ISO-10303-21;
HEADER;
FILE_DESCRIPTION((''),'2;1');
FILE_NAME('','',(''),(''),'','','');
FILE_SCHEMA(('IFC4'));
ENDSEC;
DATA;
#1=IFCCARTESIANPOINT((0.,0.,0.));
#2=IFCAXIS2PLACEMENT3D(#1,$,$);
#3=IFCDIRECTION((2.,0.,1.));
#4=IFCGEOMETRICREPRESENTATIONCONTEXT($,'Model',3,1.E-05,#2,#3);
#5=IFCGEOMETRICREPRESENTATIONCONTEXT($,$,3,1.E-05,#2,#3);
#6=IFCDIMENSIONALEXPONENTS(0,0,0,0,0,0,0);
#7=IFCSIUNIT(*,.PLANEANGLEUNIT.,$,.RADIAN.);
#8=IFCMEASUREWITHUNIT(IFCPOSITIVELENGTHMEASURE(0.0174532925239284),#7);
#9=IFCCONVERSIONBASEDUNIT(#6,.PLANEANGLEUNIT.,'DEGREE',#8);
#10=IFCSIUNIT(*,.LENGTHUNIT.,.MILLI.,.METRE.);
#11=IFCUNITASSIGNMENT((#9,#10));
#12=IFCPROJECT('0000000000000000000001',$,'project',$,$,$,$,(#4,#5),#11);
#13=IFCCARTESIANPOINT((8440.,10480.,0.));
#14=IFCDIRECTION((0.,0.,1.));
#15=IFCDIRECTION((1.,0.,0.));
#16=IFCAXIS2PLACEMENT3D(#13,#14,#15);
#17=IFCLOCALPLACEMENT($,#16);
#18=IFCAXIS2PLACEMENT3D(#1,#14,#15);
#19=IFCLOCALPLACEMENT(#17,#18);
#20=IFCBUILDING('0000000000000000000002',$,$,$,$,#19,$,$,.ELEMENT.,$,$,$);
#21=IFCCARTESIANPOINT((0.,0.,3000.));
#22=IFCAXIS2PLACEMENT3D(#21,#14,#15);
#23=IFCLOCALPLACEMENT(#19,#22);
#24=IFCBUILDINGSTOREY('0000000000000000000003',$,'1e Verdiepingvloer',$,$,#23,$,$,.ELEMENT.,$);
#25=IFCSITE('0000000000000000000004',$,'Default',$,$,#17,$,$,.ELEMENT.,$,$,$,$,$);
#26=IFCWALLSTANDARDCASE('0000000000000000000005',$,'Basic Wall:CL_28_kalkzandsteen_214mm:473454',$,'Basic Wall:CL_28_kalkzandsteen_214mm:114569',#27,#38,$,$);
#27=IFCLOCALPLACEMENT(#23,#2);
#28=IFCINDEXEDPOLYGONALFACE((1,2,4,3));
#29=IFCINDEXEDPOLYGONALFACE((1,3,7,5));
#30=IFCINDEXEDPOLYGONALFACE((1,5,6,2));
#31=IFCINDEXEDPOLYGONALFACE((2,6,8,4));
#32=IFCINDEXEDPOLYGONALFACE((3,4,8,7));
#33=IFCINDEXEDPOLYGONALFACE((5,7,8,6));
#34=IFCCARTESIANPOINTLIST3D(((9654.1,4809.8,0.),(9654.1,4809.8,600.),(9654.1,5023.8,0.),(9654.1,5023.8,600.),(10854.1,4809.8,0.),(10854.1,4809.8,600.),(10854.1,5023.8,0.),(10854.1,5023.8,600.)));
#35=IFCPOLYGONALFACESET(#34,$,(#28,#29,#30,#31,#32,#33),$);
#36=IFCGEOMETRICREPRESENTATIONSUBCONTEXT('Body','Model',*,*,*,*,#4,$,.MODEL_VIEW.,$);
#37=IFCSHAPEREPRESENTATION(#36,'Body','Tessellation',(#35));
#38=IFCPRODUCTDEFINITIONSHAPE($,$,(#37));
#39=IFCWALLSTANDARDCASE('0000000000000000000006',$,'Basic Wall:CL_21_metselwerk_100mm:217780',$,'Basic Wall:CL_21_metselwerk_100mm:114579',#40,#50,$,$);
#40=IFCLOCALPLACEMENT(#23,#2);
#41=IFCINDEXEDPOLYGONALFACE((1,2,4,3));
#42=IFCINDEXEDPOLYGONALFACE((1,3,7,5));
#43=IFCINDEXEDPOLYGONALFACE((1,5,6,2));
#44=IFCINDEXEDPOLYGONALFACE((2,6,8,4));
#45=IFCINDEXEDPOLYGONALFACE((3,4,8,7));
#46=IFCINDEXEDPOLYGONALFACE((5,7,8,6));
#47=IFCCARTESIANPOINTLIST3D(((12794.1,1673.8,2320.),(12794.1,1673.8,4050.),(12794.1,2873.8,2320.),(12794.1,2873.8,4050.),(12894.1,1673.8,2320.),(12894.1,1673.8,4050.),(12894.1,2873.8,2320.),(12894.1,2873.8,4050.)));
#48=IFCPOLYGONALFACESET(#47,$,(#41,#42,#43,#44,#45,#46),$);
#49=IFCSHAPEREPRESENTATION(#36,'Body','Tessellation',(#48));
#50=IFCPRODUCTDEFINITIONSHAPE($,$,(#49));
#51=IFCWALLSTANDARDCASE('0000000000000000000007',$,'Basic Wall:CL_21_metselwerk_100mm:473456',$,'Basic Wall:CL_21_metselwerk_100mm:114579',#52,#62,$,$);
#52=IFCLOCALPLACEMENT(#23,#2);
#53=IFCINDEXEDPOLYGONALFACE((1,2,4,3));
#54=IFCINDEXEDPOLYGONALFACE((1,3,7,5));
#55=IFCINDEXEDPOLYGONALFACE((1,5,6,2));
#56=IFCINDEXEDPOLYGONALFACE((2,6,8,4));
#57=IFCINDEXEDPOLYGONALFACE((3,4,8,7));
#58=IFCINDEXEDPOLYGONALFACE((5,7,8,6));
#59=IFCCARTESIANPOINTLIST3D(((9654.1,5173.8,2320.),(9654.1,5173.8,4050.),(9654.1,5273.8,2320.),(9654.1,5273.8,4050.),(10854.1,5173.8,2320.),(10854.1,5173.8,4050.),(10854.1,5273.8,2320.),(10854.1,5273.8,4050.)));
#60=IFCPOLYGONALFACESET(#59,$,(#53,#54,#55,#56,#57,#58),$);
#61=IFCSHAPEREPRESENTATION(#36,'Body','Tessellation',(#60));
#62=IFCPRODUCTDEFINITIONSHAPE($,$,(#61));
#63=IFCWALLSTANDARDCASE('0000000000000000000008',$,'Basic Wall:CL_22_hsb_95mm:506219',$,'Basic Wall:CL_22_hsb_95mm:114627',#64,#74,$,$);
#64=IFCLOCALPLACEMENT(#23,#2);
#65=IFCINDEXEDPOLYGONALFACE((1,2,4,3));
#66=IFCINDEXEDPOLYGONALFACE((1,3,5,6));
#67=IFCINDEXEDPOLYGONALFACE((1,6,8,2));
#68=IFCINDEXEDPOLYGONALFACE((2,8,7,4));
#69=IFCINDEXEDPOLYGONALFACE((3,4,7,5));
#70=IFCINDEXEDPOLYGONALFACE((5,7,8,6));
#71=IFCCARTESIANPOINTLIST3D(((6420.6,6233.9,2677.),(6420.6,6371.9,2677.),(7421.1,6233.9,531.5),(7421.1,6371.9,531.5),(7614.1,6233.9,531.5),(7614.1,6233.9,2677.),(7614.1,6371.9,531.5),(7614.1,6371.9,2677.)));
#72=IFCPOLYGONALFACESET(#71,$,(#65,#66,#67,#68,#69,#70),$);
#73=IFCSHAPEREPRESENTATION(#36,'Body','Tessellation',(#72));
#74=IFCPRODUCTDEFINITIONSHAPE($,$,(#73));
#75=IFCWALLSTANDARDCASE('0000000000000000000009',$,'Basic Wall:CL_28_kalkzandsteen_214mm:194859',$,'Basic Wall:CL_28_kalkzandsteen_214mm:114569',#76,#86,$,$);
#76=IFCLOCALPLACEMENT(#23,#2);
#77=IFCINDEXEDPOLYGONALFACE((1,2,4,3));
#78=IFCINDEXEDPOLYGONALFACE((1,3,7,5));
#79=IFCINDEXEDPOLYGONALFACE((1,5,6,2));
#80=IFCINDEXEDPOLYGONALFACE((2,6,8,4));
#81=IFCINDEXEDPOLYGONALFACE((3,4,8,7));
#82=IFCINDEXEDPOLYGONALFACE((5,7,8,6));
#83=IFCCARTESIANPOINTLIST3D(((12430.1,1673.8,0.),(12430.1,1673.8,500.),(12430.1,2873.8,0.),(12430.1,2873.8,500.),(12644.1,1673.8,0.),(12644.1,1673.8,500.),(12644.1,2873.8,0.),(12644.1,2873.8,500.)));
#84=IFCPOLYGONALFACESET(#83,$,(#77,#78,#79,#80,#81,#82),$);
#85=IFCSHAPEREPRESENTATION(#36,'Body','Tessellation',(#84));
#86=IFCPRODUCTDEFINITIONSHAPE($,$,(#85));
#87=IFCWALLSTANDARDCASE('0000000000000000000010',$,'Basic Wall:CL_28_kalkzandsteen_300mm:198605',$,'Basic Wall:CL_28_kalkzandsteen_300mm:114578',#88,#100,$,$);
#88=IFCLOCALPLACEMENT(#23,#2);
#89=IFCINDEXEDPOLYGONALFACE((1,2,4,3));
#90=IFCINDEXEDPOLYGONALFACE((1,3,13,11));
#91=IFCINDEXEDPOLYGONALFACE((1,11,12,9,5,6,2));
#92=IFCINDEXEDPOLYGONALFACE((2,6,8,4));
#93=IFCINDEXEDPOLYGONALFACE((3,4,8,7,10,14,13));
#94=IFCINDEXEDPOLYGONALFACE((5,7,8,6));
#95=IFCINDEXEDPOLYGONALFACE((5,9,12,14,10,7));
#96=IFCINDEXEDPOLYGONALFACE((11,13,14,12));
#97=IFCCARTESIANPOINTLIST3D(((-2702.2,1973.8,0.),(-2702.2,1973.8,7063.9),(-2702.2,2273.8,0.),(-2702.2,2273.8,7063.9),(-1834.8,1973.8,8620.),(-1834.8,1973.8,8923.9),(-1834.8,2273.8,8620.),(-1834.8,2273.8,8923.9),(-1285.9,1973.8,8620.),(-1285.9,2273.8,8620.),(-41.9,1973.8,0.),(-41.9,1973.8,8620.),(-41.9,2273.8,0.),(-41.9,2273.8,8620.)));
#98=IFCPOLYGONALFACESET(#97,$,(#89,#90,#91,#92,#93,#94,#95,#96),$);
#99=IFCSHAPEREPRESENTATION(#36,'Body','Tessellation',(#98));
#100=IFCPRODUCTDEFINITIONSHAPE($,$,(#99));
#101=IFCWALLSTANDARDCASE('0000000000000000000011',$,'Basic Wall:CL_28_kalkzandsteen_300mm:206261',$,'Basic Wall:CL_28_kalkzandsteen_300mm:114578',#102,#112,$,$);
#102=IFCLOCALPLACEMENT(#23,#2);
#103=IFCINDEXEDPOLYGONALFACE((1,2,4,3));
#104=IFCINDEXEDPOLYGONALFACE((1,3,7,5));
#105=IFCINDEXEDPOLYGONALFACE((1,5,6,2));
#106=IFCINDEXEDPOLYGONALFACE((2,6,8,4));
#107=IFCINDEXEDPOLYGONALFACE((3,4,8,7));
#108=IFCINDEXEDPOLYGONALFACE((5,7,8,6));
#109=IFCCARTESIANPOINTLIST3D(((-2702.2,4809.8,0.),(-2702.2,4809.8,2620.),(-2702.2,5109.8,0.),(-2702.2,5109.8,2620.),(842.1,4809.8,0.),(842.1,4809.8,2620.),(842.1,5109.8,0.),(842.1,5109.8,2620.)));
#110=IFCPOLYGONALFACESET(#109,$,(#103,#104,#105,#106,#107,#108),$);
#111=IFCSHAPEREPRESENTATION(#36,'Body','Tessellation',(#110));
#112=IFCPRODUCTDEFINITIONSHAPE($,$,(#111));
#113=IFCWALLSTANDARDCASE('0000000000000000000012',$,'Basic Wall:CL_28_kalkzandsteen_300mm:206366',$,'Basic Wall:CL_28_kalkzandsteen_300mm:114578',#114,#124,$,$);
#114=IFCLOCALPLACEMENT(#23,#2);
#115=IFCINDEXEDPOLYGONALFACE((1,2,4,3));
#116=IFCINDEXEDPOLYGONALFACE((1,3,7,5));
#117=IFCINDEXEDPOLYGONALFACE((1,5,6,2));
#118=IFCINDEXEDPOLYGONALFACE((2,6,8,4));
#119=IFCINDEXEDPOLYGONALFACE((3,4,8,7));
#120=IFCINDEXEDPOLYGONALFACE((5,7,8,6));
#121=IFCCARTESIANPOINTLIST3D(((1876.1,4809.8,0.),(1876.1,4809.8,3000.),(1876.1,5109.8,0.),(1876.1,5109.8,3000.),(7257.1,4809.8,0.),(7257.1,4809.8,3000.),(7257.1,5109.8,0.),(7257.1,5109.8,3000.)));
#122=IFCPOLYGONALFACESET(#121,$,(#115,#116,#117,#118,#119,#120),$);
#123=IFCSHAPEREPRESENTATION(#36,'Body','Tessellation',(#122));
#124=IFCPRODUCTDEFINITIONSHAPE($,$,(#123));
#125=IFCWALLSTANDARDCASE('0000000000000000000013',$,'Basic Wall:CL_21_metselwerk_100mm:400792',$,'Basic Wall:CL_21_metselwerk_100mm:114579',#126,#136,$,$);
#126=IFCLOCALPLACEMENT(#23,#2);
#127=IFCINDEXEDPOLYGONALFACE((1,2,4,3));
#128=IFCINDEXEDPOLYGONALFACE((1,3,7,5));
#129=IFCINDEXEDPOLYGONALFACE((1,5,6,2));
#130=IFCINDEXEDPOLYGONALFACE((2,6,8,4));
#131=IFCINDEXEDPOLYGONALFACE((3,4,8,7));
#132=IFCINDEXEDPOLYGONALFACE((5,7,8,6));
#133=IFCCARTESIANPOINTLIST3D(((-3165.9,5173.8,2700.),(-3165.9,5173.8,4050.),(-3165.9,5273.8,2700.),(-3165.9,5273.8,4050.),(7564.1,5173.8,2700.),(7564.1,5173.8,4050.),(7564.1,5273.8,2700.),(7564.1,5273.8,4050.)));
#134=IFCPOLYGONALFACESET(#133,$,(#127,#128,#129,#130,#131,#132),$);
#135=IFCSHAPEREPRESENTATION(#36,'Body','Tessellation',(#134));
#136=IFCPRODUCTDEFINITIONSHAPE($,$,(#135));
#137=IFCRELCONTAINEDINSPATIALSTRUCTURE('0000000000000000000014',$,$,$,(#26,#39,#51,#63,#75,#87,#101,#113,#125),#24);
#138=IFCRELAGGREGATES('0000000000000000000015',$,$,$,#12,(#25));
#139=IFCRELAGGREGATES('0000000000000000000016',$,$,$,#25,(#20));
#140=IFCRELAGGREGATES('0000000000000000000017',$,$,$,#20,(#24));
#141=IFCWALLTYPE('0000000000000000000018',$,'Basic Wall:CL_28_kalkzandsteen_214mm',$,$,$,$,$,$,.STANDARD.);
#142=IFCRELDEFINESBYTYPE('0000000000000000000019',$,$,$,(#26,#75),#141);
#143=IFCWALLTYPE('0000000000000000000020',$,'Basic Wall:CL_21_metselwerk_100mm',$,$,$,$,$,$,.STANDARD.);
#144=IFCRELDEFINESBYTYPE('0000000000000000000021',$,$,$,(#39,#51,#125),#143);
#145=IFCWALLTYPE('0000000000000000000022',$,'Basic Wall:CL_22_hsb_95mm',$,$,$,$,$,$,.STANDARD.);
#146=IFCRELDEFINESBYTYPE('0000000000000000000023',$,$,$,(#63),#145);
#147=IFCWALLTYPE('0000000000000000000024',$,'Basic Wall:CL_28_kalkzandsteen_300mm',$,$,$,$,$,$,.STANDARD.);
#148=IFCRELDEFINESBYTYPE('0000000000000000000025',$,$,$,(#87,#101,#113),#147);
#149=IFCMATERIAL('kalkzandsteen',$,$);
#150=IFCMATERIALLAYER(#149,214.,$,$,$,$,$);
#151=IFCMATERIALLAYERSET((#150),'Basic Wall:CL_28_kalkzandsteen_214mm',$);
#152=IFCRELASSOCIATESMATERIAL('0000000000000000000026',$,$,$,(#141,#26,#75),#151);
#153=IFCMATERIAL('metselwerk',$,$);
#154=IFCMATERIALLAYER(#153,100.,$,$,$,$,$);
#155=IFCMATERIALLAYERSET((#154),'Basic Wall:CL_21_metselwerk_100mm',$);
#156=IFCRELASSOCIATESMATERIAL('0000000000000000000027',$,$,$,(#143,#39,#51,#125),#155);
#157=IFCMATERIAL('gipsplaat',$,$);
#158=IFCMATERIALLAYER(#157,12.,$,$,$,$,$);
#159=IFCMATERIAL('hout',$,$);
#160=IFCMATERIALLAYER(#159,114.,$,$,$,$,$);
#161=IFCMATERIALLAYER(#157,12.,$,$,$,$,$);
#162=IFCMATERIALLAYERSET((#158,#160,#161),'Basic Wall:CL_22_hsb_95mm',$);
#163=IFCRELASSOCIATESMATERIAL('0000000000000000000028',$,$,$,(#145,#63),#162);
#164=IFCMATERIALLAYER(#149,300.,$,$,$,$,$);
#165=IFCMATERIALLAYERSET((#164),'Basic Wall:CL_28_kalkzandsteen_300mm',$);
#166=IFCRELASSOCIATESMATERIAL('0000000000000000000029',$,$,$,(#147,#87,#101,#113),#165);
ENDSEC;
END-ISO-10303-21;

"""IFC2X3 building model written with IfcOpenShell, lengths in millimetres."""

from ifc_helpers import new_model, entity, si_unit, converted_unit, direction, frame, frame_2d, origin, origin_with_axes, place, context, subcontext, project, spatial, polyline, rectangle, extrude, clip, halfspace, bounded_halfspace, source, transform, mapped, material, layer, layer_set, layer_usage, type_object, element, save


model = new_model("IFC2X3")

# Units and contexts
model_context = context("Model", 3, precision=1e-05, world=origin(), true_north=direction((2.0, 0.0, 1.0)))
context_of_model = context(None, 3, precision=1e-05, world=origin(), true_north=direction((2.0, 0.0, 1.0)))
body_context = subcontext(model_context, "Body", "Model", "MODEL_VIEW")
ifc_project = project(units=[converted_unit("PLANEANGLEUNIT", "DEGREE", entity("IfcPositiveLengthMeasure", 0.0174532925239284), si_unit("PLANEANGLEUNIT", "RADIAN"), dimensions=[0, 0, 0, 0, 0, 0, 0]), si_unit("LENGTHUNIT", "METRE", prefix="MILLI")], contexts=[model_context, context_of_model])

# Site, building, storey
site_placement = place(None, frame((8440.0, 10480.0, 0.0), z_axis=(0.0, 0.0, 1.0), x_axis=(1.0, 0.0, 0.0)))
site = spatial("IfcSite", under=ifc_project, at=site_placement, Name="Default", CompositionType="ELEMENT")
building_placement = place(site_placement, origin_with_axes())
building = spatial("IfcBuilding", under=site, at=building_placement, CompositionType="ELEMENT")
storey_placement = place(building_placement, frame((0.0, 0.0, 3000.0), z_axis=(0.0, 0.0, 1.0), x_axis=(1.0, 0.0, 0.0)))
storey = spatial("IfcBuildingStorey", under=building, at=storey_placement, Name="1e Verdiepingvloer", CompositionType="ELEMENT")

# Shared definitions
ifc_material_1 = material(Name="hout")

# Walls
ifc_material_2 = material(Name="kalkzandsteen")
ifc_layer_1 = layer(ifc_material_2, 214.0)
ifc_layer_set_1 = layer_set([ifc_layer_1], Name="Basic Wall:CL_28_kalkzandsteen_214mm")
ifc_layer_usage_1 = layer_usage(ifc_layer_set_1, "AXIS2", "NEGATIVE", 107.0)
wall_type_1 = type_object("IfcWallType", Name="Basic Wall:CL_28_kalkzandsteen_214mm", PredefinedType="STANDARD", material=ifc_layer_set_1)
shared_shape_1 = source(origin(), body_context, "Body", "SweptSolid", [
    extrude(rectangle(XDim=1200.0, YDim=214.0, at=frame_2d((600.0, 0.0), x_axis=(-1.0, 0.0))), origin(), (0.0, 0.0, 1.0), 600.0),
])
wall_1_placement = place(storey_placement, frame((10854.1, 4916.8, 0.0), z_axis=(0.0, 0.0, 1.0), x_axis=(-1.0, 0.0, 0.0)))
element("IfcWallStandardCase", 1, at=wall_1_placement, inside=storey, type_object=wall_type_1, material=ifc_layer_usage_1, Name="Basic Wall:CL_28_kalkzandsteen_214mm:473454", ObjectType="Basic Wall:CL_28_kalkzandsteen_214mm:114569", context=body_context, shape_type="MappedRepresentation", body=[
    mapped(shared_shape_1, transform((0.0, 0.0, 0.0))),
])
ifc_material_3 = material(Name="metselwerk")
ifc_layer_2 = layer(ifc_material_3, 100.0)
ifc_layer_set_2 = layer_set([ifc_layer_2], Name="Basic Wall:CL_21_metselwerk_100mm")
ifc_layer_usage_2 = layer_usage(ifc_layer_set_2, "AXIS2", "NEGATIVE", 50.0)
wall_type_2 = type_object("IfcWallType", Name="Basic Wall:CL_21_metselwerk_100mm", PredefinedType="STANDARD", material=ifc_layer_set_2)
shared_shape_2 = source(origin(), body_context, "Body", "SweptSolid", [
    extrude(rectangle(XDim=1200.0, YDim=100.0, at=frame_2d((600.0, 0.0), x_axis=(-1.0, 0.0))), origin(), (0.0, 0.0, 1.0), 1730.0),
])
wall_2_placement = place(storey_placement, frame((12844.1, 1673.8, 2320.0), z_axis=(0.0, 0.0, 1.0), x_axis=(0.0, 1.0, 0.0)))
element("IfcWallStandardCase", 2, at=wall_2_placement, inside=storey, type_object=wall_type_2, material=ifc_layer_usage_2, Name="Basic Wall:CL_21_metselwerk_100mm:217780", ObjectType="Basic Wall:CL_21_metselwerk_100mm:114579", context=body_context, shape_type="MappedRepresentation", body=[
    mapped(shared_shape_2, transform((0.0, 0.0, 0.0))),
])
ifc_layer_usage_3 = layer_usage(ifc_layer_set_2, "AXIS2", "NEGATIVE", 50.0)
wall_3_placement = place(storey_placement, frame((10854.1, 5223.8, 2320.0), z_axis=(0.0, 0.0, 1.0), x_axis=(-1.0, 0.0, 0.0)))
element("IfcWallStandardCase", 3, at=wall_3_placement, inside=storey, type_object=wall_type_2, material=ifc_layer_usage_3, Name="Basic Wall:CL_21_metselwerk_100mm:473456", ObjectType="Basic Wall:CL_21_metselwerk_100mm:114579", context=body_context, shape_type="MappedRepresentation", body=[
    mapped(shared_shape_2, transform((0.0, 0.0, 0.0))),
])
ifc_material_4 = material(Name="gipsplaat")
ifc_layer_3 = layer(ifc_material_4, 12.0)
ifc_layer_4 = layer(ifc_material_1, 114.0)
ifc_layer_5 = layer(ifc_material_4, 12.0)
ifc_layer_set_3 = layer_set([ifc_layer_3, ifc_layer_4, ifc_layer_5], Name="Basic Wall:CL_22_hsb_95mm")
ifc_layer_usage_4 = layer_usage(ifc_layer_set_3, "AXIS2", "NEGATIVE", 69.0)
wall_type_3 = type_object("IfcWallType", Name="Basic Wall:CL_22_hsb_95mm", PredefinedType="STANDARD", material=ifc_layer_set_3)
shared_shape_3 = source(origin(), body_context, "Body", "Clipping", [
    clip(clip(extrude(rectangle(XDim=1193.5, YDim=138.0, at=frame_2d((596.7, 0.0), x_axis=(-1.0, 0.0))), origin(), (0.0, 0.0, 1.0), 2677.0), halfspace(frame((1000.5, -69.0, 531.5), z_axis=(-0.906308, 0.0, -0.422618), x_axis=(0.0, 1.0, 0.0)), False)), halfspace(frame((1193.5, -69.0, 531.5), z_axis=(0.0, 0.0, -1.0), x_axis=(0.0, 1.0, 0.0)), False)),
])
wall_4_placement = place(storey_placement, frame((6420.6, 6302.9, 0.0), z_axis=(0.0, 0.0, 1.0), x_axis=(1.0, 0.0, 0.0)))
element("IfcWallStandardCase", 4, at=wall_4_placement, inside=storey, type_object=wall_type_3, material=ifc_layer_usage_4, Name="Basic Wall:CL_22_hsb_95mm:506219", ObjectType="Basic Wall:CL_22_hsb_95mm:114627", context=body_context, shape_type="MappedRepresentation", body=[
    mapped(shared_shape_3, transform((0.0, 0.0, 0.0))),
])
ifc_layer_usage_5 = layer_usage(ifc_layer_set_1, "AXIS2", "NEGATIVE", 107.0)
wall_5_placement = place(storey_placement, frame((12537.1, 1673.8, 0.0), z_axis=(0.0, 0.0, 1.0), x_axis=(0.0, 1.0, 0.0)))
element("IfcWallStandardCase", 5, at=wall_5_placement, inside=storey, type_object=wall_type_1, material=ifc_layer_usage_5, Name="Basic Wall:CL_28_kalkzandsteen_214mm:194859", ObjectType="Basic Wall:CL_28_kalkzandsteen_214mm:114569", context=body_context, shape_type="SweptSolid", body=[
    extrude(rectangle(XDim=1200.0, YDim=214.0, at=frame_2d((600.0, 0.0), x_axis=(-1.0, 0.0))), origin(), (0.0, 0.0, 1.0), 500.0),
])
ifc_layer_6 = layer(ifc_material_2, 300.0)
ifc_layer_set_4 = layer_set([ifc_layer_6], Name="Basic Wall:CL_28_kalkzandsteen_300mm")
ifc_layer_usage_6 = layer_usage(ifc_layer_set_4, "AXIS2", "NEGATIVE", 150.0)
wall_type_4 = type_object("IfcWallType", Name="Basic Wall:CL_28_kalkzandsteen_300mm", PredefinedType="STANDARD", material=ifc_layer_set_4)
wall_6_placement = place(storey_placement, frame((-41.9, 2123.8, 0.0), z_axis=(0.0, 0.0, 1.0), x_axis=(-1.0, 0.0, 0.0)))
element("IfcWallStandardCase", 6, at=wall_6_placement, inside=storey, type_object=wall_type_4, material=ifc_layer_usage_6, Name="Basic Wall:CL_28_kalkzandsteen_300mm:198605", ObjectType="Basic Wall:CL_28_kalkzandsteen_300mm:114578", context=body_context, shape_type="Clipping", body=[
    clip(clip(clip(clip(extrude(rectangle(XDim=2660.3, YDim=300.0, at=frame_2d((1330.1, 0.0), x_axis=(-1.0, 0.0))), origin(), (0.0, 0.0, 1.0), 8923.9), bounded_halfspace(frame((0.0, -150.0, 8620.0), z_axis=(0.0, 0.0, -1.0), x_axis=(0.0, 1.0, 0.0)), True, frame((0.0, -150.0, 8620.0)), polyline([(0.0, 0.0), (1244.0, 0.0), (1244.0, 300.0), (0.0, 300.0), (0.0, 0.0)]))), bounded_halfspace(frame((1792.9, -150.0, 8923.9), z_axis=(0.906308, 0.0, 0.422618), x_axis=(0.0, 1.0, 0.0)), False, frame((1792.9, -150.0, 8923.9)), polyline([(0.0, 0.0), (867.4, 0.0), (867.4, 300.0), (0.0, 300.0), (0.0, 0.0)]))), bounded_halfspace(frame((0.0, -150.0, 8620.0), z_axis=(0.0, 0.0, -1.0), x_axis=(0.0, 1.0, 0.0)), True, frame((0.0, -150.0, 8620.0)), polyline([(0.0, 0.0), (1244.0, 0.0), (1244.0, 300.0), (0.0, 300.0), (0.0, 0.0)]))), bounded_halfspace(frame((1244.0, -150.0, 8620.0), z_axis=(0.0, 0.0, 1.0), x_axis=(0.0, 1.0, 0.0)), False, frame((1244.0, -150.0, 8620.0)), polyline([(0.0, 0.0), (548.9, 0.0), (548.9, 300.0), (0.0, 300.0), (0.0, 0.0)]))),
])
ifc_layer_usage_7 = layer_usage(ifc_layer_set_4, "AXIS2", "NEGATIVE", 150.0)
wall_7_placement = place(storey_placement, frame((842.1, 4959.8, 0.0), z_axis=(0.0, 0.0, 1.0), x_axis=(-1.0, 0.0, 0.0)))
element("IfcWallStandardCase", 7, at=wall_7_placement, inside=storey, type_object=wall_type_4, material=ifc_layer_usage_7, Name="Basic Wall:CL_28_kalkzandsteen_300mm:206261", ObjectType="Basic Wall:CL_28_kalkzandsteen_300mm:114578", context=body_context, shape_type="SweptSolid", body=[
    extrude(rectangle(XDim=3544.3, YDim=300.0, at=frame_2d((1772.1, 0.0), x_axis=(-1.0, 0.0))), origin(), (0.0, 0.0, 1.0), 2620.0),
])
ifc_layer_usage_8 = layer_usage(ifc_layer_set_4, "AXIS2", "NEGATIVE", 150.0)
wall_8_placement = place(storey_placement, frame((7257.1, 4959.8, 0.0), z_axis=(0.0, 0.0, 1.0), x_axis=(-1.0, 0.0, 0.0)))
element("IfcWallStandardCase", 8, at=wall_8_placement, inside=storey, type_object=wall_type_4, material=ifc_layer_usage_8, Name="Basic Wall:CL_28_kalkzandsteen_300mm:206366", ObjectType="Basic Wall:CL_28_kalkzandsteen_300mm:114578", context=body_context, shape_type="SweptSolid", body=[
    extrude(rectangle(XDim=5381.0, YDim=300.0, at=frame_2d((2690.5, 0.0), x_axis=(-1.0, 0.0))), origin(), (0.0, 0.0, 1.0), 3000.0),
])
ifc_layer_usage_9 = layer_usage(ifc_layer_set_2, "AXIS2", "NEGATIVE", 50.0)
wall_9_placement = place(storey_placement, frame((7564.1, 5223.8, 2700.0), z_axis=(0.0, 0.0, 1.0), x_axis=(-1.0, 0.0, 0.0)))
element("IfcWallStandardCase", 9, at=wall_9_placement, inside=storey, type_object=wall_type_2, material=ifc_layer_usage_9, Name="Basic Wall:CL_21_metselwerk_100mm:400792", ObjectType="Basic Wall:CL_21_metselwerk_100mm:114579", context=body_context, shape_type="SweptSolid", body=[
    extrude(rectangle(XDim=10730.0, YDim=100.0, at=frame_2d((5365.0, 0.0), x_axis=(-1.0, 0.0))), origin(), (0.0, 0.0, 1.0), 1350.0),
])

save(model, "model.ifc")
